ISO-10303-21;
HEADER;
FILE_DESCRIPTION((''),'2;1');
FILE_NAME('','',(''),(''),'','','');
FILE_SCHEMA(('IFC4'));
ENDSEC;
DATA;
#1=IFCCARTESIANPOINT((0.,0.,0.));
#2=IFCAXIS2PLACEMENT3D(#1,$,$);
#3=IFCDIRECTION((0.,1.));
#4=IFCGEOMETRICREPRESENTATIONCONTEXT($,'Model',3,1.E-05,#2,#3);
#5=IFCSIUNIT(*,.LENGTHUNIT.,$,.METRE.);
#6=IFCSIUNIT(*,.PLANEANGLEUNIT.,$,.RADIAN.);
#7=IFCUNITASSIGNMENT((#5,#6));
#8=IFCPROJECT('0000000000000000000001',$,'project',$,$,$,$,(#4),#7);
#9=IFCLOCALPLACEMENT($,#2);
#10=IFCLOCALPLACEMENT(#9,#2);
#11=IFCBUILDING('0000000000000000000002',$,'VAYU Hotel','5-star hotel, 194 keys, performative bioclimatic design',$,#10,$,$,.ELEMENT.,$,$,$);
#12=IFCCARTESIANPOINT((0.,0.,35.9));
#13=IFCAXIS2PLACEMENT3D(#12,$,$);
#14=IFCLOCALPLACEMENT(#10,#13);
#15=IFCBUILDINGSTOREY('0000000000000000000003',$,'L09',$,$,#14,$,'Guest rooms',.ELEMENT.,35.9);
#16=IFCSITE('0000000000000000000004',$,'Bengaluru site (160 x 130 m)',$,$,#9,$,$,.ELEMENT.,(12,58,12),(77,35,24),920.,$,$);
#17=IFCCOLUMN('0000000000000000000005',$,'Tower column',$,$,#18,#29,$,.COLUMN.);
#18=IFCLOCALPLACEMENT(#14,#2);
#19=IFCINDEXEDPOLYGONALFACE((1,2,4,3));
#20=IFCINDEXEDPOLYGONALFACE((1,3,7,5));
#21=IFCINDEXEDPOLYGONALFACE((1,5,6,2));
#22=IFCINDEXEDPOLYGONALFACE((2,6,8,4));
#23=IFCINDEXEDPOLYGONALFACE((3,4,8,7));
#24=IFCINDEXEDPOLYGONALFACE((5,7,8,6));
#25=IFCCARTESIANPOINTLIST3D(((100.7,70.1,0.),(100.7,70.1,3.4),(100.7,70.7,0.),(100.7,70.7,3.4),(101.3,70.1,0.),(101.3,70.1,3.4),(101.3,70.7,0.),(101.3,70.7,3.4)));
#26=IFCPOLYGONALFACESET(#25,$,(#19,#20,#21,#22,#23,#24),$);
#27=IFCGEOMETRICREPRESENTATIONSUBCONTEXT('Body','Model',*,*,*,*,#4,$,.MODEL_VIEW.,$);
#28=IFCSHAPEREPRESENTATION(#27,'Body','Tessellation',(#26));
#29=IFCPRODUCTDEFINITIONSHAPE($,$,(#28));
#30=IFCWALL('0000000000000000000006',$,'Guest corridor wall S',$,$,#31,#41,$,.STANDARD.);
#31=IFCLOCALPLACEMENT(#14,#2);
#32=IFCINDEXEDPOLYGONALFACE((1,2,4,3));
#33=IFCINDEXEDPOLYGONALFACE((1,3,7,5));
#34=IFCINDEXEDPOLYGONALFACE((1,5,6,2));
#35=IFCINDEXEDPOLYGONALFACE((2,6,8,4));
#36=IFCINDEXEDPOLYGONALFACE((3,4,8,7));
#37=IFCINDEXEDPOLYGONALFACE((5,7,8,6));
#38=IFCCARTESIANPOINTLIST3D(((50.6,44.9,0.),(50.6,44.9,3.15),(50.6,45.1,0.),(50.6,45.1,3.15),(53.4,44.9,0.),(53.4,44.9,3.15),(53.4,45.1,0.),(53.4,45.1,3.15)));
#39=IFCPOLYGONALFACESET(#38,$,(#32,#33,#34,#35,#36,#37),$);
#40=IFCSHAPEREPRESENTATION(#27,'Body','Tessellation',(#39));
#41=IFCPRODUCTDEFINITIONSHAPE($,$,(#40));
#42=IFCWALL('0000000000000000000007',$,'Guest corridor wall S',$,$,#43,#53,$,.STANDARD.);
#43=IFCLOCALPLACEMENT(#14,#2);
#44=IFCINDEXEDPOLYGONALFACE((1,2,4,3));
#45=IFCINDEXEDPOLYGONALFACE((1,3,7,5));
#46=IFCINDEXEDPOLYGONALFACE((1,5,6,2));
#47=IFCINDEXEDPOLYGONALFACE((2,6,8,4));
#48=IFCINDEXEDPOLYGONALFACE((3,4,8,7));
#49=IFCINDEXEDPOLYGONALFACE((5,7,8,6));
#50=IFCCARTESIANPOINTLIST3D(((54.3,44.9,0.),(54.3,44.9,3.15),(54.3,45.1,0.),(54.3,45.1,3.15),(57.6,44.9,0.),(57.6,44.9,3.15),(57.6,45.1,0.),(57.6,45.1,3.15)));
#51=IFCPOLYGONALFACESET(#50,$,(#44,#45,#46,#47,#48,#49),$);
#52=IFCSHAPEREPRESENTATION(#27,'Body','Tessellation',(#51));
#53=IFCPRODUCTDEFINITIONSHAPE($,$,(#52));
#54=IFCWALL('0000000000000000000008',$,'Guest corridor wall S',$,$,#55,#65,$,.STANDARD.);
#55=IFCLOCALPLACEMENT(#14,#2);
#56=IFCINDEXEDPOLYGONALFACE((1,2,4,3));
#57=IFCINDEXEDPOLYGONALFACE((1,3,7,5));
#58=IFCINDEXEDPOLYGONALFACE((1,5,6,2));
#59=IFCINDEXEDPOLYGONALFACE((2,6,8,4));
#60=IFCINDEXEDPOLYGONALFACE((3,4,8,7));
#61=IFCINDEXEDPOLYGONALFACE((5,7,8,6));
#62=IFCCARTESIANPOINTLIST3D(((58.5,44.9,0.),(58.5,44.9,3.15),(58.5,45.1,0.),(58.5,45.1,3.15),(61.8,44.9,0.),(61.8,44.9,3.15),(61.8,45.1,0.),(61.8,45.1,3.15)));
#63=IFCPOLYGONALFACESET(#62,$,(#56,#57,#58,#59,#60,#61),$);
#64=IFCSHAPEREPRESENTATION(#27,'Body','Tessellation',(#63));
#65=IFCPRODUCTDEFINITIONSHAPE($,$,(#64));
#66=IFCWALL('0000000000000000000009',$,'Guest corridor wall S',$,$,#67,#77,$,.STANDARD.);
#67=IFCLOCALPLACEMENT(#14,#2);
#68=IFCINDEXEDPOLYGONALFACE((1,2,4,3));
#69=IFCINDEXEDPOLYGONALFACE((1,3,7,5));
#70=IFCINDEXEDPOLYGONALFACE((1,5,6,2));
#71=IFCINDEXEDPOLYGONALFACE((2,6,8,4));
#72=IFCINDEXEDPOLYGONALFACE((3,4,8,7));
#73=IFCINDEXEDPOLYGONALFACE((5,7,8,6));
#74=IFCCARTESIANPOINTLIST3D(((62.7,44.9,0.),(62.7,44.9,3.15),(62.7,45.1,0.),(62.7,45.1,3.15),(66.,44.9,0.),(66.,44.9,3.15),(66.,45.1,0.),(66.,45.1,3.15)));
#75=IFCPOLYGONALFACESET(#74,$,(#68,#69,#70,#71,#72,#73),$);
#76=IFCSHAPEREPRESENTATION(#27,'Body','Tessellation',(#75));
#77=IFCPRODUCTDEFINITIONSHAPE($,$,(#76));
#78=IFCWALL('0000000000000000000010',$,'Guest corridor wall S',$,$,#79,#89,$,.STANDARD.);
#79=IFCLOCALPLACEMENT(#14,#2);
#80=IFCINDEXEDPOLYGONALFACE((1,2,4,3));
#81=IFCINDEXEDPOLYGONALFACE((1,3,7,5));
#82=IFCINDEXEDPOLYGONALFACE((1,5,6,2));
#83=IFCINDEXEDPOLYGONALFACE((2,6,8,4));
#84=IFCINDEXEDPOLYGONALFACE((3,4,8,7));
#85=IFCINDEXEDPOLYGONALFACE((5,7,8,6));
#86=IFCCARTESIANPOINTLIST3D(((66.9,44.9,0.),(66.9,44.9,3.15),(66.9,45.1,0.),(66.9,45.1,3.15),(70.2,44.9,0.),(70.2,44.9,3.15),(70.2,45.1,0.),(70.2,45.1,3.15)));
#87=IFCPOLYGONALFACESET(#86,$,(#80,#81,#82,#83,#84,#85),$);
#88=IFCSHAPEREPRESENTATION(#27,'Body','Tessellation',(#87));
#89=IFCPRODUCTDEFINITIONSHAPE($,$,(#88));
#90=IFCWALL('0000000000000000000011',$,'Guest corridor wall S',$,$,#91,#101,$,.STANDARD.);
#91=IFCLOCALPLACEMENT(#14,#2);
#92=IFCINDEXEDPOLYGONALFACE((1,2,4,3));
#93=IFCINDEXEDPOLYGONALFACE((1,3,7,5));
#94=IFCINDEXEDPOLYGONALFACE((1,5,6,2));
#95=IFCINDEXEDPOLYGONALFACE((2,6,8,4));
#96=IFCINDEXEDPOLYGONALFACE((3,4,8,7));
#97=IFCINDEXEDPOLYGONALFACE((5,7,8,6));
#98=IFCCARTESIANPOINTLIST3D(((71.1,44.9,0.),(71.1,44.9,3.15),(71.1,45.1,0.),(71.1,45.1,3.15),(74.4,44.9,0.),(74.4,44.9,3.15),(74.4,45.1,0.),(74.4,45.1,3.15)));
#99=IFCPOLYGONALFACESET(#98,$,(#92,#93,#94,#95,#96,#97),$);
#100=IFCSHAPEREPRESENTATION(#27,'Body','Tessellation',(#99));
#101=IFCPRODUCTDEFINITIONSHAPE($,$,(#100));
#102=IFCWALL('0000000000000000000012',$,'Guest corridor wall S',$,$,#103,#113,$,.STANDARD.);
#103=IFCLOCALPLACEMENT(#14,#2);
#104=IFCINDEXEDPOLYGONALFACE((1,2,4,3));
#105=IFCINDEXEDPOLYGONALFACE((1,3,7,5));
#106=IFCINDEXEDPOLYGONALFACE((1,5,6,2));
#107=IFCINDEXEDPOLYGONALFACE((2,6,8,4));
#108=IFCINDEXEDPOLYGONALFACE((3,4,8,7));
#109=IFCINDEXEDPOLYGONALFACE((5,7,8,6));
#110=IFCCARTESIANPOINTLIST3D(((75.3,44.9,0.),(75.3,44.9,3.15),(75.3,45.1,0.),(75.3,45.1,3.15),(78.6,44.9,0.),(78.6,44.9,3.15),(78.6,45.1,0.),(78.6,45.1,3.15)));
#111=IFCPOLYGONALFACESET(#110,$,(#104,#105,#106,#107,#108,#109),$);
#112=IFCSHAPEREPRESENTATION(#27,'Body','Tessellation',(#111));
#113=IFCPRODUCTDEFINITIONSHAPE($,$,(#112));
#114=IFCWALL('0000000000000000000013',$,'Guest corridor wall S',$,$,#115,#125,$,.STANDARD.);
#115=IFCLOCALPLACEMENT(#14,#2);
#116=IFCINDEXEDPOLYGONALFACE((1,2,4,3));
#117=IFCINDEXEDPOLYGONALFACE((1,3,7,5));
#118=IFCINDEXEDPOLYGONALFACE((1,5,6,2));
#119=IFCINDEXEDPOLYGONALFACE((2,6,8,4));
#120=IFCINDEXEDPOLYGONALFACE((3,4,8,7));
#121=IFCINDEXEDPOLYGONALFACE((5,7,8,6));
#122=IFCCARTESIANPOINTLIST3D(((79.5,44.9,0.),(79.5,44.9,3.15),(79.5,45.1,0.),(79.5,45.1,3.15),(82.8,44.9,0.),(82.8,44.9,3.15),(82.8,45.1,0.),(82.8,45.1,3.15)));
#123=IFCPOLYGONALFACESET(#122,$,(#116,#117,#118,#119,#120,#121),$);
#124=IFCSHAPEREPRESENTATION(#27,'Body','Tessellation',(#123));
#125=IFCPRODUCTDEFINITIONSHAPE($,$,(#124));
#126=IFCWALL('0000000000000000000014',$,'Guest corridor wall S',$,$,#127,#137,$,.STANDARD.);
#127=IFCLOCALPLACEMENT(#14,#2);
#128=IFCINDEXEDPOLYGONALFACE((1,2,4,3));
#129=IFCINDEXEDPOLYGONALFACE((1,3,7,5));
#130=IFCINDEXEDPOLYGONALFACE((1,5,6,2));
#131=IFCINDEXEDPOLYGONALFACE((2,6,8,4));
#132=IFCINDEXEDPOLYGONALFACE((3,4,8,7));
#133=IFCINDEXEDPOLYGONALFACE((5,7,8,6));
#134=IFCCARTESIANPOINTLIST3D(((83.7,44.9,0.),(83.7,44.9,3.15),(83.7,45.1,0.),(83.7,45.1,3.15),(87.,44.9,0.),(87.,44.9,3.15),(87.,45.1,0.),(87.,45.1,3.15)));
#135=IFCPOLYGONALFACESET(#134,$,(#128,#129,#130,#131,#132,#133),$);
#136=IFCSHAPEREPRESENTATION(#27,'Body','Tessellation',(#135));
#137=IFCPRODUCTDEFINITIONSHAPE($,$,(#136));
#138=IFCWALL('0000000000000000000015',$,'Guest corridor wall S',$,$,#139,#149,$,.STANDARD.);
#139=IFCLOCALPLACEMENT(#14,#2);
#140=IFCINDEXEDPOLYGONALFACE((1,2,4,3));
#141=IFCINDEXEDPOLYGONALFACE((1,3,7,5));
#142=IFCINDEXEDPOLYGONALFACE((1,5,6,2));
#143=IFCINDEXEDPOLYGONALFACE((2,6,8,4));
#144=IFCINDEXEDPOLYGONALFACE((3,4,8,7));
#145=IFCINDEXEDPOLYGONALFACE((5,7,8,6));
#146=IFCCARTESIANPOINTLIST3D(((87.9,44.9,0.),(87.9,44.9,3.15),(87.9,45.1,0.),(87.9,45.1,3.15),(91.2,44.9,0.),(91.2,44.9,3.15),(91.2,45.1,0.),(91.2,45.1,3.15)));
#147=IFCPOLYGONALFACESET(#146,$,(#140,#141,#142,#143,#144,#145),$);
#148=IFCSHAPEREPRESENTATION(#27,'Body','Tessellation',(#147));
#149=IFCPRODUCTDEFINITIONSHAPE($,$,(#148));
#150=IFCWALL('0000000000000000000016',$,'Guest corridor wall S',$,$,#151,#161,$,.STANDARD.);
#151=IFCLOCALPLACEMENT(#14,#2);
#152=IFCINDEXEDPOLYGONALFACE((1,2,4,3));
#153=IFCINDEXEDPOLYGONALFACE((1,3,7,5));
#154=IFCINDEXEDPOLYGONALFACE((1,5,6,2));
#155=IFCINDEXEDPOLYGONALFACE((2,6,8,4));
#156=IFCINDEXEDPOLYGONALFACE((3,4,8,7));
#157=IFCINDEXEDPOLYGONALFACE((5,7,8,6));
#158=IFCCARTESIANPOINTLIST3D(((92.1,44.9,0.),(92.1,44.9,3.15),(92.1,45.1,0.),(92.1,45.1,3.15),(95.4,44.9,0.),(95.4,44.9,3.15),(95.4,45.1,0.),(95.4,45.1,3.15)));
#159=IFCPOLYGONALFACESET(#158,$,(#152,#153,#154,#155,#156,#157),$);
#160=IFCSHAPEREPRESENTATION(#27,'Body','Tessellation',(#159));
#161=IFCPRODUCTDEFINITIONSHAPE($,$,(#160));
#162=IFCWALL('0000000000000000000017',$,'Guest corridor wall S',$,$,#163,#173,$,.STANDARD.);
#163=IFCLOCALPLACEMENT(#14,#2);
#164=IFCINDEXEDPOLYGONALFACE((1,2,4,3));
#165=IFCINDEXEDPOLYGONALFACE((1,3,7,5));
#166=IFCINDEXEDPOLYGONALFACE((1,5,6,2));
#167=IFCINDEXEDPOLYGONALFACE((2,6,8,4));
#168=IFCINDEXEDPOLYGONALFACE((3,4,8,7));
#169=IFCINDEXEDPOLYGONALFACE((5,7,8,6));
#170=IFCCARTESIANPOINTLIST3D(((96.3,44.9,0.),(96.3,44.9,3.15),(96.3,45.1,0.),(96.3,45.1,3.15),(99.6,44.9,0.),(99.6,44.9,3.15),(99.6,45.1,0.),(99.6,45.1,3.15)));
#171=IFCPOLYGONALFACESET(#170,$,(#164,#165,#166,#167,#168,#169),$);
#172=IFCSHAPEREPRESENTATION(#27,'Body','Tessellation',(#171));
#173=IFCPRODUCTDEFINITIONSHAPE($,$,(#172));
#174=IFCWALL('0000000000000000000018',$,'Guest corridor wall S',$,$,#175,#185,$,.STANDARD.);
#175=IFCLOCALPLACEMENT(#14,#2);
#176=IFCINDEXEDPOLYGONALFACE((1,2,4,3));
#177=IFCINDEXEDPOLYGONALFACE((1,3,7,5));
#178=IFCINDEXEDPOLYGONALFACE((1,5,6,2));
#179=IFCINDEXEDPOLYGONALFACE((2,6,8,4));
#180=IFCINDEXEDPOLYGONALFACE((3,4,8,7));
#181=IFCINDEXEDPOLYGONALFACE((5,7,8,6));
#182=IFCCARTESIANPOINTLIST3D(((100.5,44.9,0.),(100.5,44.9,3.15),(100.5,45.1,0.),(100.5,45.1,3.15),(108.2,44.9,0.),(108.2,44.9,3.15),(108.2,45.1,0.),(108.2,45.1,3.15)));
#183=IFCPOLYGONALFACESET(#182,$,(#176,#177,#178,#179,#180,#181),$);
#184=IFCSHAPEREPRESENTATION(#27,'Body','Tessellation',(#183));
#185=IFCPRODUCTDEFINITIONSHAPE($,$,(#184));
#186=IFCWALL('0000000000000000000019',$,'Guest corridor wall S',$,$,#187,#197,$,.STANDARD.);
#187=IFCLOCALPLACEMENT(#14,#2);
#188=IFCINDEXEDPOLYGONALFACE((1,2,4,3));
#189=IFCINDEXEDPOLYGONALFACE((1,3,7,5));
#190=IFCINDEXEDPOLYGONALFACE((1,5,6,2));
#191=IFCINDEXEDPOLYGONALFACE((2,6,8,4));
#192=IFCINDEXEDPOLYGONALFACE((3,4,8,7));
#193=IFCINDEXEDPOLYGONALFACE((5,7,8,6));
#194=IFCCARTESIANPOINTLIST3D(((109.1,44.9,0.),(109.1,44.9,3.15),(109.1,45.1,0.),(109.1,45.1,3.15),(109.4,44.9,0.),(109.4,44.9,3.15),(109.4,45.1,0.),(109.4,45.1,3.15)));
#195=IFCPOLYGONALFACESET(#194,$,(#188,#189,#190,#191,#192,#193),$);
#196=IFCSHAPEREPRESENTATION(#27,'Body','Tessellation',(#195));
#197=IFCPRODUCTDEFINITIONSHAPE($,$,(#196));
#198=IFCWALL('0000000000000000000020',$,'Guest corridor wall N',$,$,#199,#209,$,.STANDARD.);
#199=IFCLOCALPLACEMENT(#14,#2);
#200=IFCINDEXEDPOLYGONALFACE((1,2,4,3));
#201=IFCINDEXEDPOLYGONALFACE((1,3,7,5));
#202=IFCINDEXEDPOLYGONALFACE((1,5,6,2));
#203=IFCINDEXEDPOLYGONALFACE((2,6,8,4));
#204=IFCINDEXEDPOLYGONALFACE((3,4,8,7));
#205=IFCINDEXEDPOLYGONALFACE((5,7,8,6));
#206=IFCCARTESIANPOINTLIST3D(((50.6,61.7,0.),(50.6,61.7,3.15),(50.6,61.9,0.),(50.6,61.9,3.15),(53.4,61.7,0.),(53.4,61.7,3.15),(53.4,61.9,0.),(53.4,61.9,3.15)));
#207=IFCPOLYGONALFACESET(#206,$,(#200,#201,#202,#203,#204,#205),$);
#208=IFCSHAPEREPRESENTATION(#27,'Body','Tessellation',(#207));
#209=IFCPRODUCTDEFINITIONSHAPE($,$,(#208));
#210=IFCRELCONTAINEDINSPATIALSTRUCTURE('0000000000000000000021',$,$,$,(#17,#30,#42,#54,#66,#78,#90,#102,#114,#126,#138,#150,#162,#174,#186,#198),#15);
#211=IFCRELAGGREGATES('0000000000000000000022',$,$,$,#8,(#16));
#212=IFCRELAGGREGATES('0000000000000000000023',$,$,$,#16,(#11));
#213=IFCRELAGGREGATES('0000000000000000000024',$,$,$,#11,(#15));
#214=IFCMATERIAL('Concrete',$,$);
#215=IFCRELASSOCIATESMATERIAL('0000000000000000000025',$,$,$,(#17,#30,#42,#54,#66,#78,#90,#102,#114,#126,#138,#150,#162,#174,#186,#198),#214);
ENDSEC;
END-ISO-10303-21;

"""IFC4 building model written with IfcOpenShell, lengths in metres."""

from ifc_helpers import new_model, si_unit, direction, frame, origin, place, context, subcontext, project, spatial, polyline, outline, extrude, material, element, save


model = new_model("IFC4")

# Units and contexts
model_context = context("Model", 3, precision=1e-05, world=origin(), true_north=direction((0.0, 1.0)))
body_context = subcontext(model_context, "Body", "Model", "MODEL_VIEW")
ifc_project = project(units=[si_unit("LENGTHUNIT", "METRE"), si_unit("PLANEANGLEUNIT", "RADIAN")], contexts=[model_context])

# Site, building, storey
site_placement = place(None, origin())
site = spatial("IfcSite", under=ifc_project, at=site_placement, Name="Bengaluru site (160 x 130 m)", CompositionType="ELEMENT", RefLatitude=(12, 58, 12), RefLongitude=(77, 35, 24), RefElevation=920.0)
building_placement = place(site_placement, origin())
building = spatial("IfcBuilding", under=site, at=building_placement, Name="VAYU Hotel", Description="5-star hotel, 194 keys, performative bioclimatic design", CompositionType="ELEMENT")
storey_placement = place(building_placement, frame((0.0, 0.0, 35.9)))
storey = spatial("IfcBuildingStorey", under=building, at=storey_placement, Name="L09", LongName="Guest rooms", CompositionType="ELEMENT", Elevation=35.9)

# Column
ifc_material = material(Name="Concrete")
column_1_placement = place(storey_placement, origin())
element("IfcColumn", 1, at=column_1_placement, inside=storey, material=ifc_material, Name="Tower column", PredefinedType="COLUMN", context=body_context, shape_type="SweptSolid", body=[
    extrude(outline(polyline([(100.7, 70.1), (101.3, 70.1), (101.3, 70.7), (100.7, 70.7), (100.7, 70.1)])), origin(), (0.0, 0.0, 1.0), 3.4),
])

# Walls
wall_1_placement = place(storey_placement, origin())
element("IfcWall", 2, at=wall_1_placement, inside=storey, material=ifc_material, Name="Guest corridor wall S", PredefinedType="STANDARD", context=body_context, shape_type="SweptSolid", body=[
    extrude(outline(polyline([(50.6, 45.1), (53.4, 45.1), (53.4, 44.9), (50.6, 44.9), (50.6, 45.1)])), origin(), (0.0, 0.0, 1.0), 3.15),
])
wall_2_placement = place(storey_placement, origin())
element("IfcWall", 3, at=wall_2_placement, inside=storey, material=ifc_material, Name="Guest corridor wall S", PredefinedType="STANDARD", context=body_context, shape_type="SweptSolid", body=[
    extrude(outline(polyline([(54.3, 45.1), (57.6, 45.1), (57.6, 44.9), (54.3, 44.9), (54.3, 45.1)])), origin(), (0.0, 0.0, 1.0), 3.15),
])
wall_3_placement = place(storey_placement, origin())
element("IfcWall", 4, at=wall_3_placement, inside=storey, material=ifc_material, Name="Guest corridor wall S", PredefinedType="STANDARD", context=body_context, shape_type="SweptSolid", body=[
    extrude(outline(polyline([(58.5, 45.1), (61.8, 45.1), (61.8, 44.9), (58.5, 44.9), (58.5, 45.1)])), origin(), (0.0, 0.0, 1.0), 3.15),
])
wall_4_placement = place(storey_placement, origin())
element("IfcWall", 5, at=wall_4_placement, inside=storey, material=ifc_material, Name="Guest corridor wall S", PredefinedType="STANDARD", context=body_context, shape_type="SweptSolid", body=[
    extrude(outline(polyline([(62.7, 45.1), (66.0, 45.1), (66.0, 44.9), (62.7, 44.9), (62.7, 45.1)])), origin(), (0.0, 0.0, 1.0), 3.15),
])
wall_5_placement = place(storey_placement, origin())
element("IfcWall", 6, at=wall_5_placement, inside=storey, material=ifc_material, Name="Guest corridor wall S", PredefinedType="STANDARD", context=body_context, shape_type="SweptSolid", body=[
    extrude(outline(polyline([(66.9, 45.1), (70.2, 45.1), (70.2, 44.9), (66.9, 44.9), (66.9, 45.1)])), origin(), (0.0, 0.0, 1.0), 3.15),
])
wall_6_placement = place(storey_placement, origin())
element("IfcWall", 7, at=wall_6_placement, inside=storey, material=ifc_material, Name="Guest corridor wall S", PredefinedType="STANDARD", context=body_context, shape_type="SweptSolid", body=[
    extrude(outline(polyline([(71.1, 45.1), (74.4, 45.1), (74.4, 44.9), (71.1, 44.9), (71.1, 45.1)])), origin(), (0.0, 0.0, 1.0), 3.15),
])
wall_7_placement = place(storey_placement, origin())
element("IfcWall", 8, at=wall_7_placement, inside=storey, material=ifc_material, Name="Guest corridor wall S", PredefinedType="STANDARD", context=body_context, shape_type="SweptSolid", body=[
    extrude(outline(polyline([(75.3, 45.1), (78.6, 45.1), (78.6, 44.9), (75.3, 44.9), (75.3, 45.1)])), origin(), (0.0, 0.0, 1.0), 3.15),
])
wall_8_placement = place(storey_placement, origin())
element("IfcWall", 9, at=wall_8_placement, inside=storey, material=ifc_material, Name="Guest corridor wall S", PredefinedType="STANDARD", context=body_context, shape_type="SweptSolid", body=[
    extrude(outline(polyline([(79.5, 45.1), (82.8, 45.1), (82.8, 44.9), (79.5, 44.9), (79.5, 45.1)])), origin(), (0.0, 0.0, 1.0), 3.15),
])
wall_9_placement = place(storey_placement, origin())
element("IfcWall", 10, at=wall_9_placement, inside=storey, material=ifc_material, Name="Guest corridor wall S", PredefinedType="STANDARD", context=body_context, shape_type="SweptSolid", body=[
    extrude(outline(polyline([(83.7, 45.1), (87.0, 45.1), (87.0, 44.9), (83.7, 44.9), (83.7, 45.1)])), origin(), (0.0, 0.0, 1.0), 3.15),
])
wall_10_placement = place(storey_placement, origin())
element("IfcWall", 11, at=wall_10_placement, inside=storey, material=ifc_material, Name="Guest corridor wall S", PredefinedType="STANDARD", context=body_context, shape_type="SweptSolid", body=[
    extrude(outline(polyline([(87.9, 45.1), (91.2, 45.1), (91.2, 44.9), (87.9, 44.9), (87.9, 45.1)])), origin(), (0.0, 0.0, 1.0), 3.15),
])
wall_11_placement = place(storey_placement, origin())
element("IfcWall", 12, at=wall_11_placement, inside=storey, material=ifc_material, Name="Guest corridor wall S", PredefinedType="STANDARD", context=body_context, shape_type="SweptSolid", body=[
    extrude(outline(polyline([(92.1, 45.1), (95.4, 45.1), (95.4, 44.9), (92.1, 44.9), (92.1, 45.1)])), origin(), (0.0, 0.0, 1.0), 3.15),
])
wall_12_placement = place(storey_placement, origin())
element("IfcWall", 13, at=wall_12_placement, inside=storey, material=ifc_material, Name="Guest corridor wall S", PredefinedType="STANDARD", context=body_context, shape_type="SweptSolid", body=[
    extrude(outline(polyline([(96.3, 45.1), (99.6, 45.1), (99.6, 44.9), (96.3, 44.9), (96.3, 45.1)])), origin(), (0.0, 0.0, 1.0), 3.15),
])
wall_13_placement = place(storey_placement, origin())
element("IfcWall", 14, at=wall_13_placement, inside=storey, material=ifc_material, Name="Guest corridor wall S", PredefinedType="STANDARD", context=body_context, shape_type="SweptSolid", body=[
    extrude(outline(polyline([(100.5, 45.1), (108.2, 45.1), (108.2, 44.9), (100.5, 44.9), (100.5, 45.1)])), origin(), (0.0, 0.0, 1.0), 3.15),
])
wall_14_placement = place(storey_placement, origin())
element("IfcWall", 15, at=wall_14_placement, inside=storey, material=ifc_material, Name="Guest corridor wall S", PredefinedType="STANDARD", context=body_context, shape_type="SweptSolid", body=[
    extrude(outline(polyline([(109.1, 45.1), (109.4, 45.1), (109.4, 44.9), (109.1, 44.9), (109.1, 45.1)])), origin(), (0.0, 0.0, 1.0), 3.15),
])
wall_15_placement = place(storey_placement, origin())
element("IfcWall", 16, at=wall_15_placement, inside=storey, material=ifc_material, Name="Guest corridor wall N", PredefinedType="STANDARD", context=body_context, shape_type="SweptSolid", body=[
    extrude(outline(polyline([(50.6, 61.9), (53.4, 61.9), (53.4, 61.7), (50.6, 61.7), (50.6, 61.9)])), origin(), (0.0, 0.0, 1.0), 3.15),
])

save(model, "model.ifc")
